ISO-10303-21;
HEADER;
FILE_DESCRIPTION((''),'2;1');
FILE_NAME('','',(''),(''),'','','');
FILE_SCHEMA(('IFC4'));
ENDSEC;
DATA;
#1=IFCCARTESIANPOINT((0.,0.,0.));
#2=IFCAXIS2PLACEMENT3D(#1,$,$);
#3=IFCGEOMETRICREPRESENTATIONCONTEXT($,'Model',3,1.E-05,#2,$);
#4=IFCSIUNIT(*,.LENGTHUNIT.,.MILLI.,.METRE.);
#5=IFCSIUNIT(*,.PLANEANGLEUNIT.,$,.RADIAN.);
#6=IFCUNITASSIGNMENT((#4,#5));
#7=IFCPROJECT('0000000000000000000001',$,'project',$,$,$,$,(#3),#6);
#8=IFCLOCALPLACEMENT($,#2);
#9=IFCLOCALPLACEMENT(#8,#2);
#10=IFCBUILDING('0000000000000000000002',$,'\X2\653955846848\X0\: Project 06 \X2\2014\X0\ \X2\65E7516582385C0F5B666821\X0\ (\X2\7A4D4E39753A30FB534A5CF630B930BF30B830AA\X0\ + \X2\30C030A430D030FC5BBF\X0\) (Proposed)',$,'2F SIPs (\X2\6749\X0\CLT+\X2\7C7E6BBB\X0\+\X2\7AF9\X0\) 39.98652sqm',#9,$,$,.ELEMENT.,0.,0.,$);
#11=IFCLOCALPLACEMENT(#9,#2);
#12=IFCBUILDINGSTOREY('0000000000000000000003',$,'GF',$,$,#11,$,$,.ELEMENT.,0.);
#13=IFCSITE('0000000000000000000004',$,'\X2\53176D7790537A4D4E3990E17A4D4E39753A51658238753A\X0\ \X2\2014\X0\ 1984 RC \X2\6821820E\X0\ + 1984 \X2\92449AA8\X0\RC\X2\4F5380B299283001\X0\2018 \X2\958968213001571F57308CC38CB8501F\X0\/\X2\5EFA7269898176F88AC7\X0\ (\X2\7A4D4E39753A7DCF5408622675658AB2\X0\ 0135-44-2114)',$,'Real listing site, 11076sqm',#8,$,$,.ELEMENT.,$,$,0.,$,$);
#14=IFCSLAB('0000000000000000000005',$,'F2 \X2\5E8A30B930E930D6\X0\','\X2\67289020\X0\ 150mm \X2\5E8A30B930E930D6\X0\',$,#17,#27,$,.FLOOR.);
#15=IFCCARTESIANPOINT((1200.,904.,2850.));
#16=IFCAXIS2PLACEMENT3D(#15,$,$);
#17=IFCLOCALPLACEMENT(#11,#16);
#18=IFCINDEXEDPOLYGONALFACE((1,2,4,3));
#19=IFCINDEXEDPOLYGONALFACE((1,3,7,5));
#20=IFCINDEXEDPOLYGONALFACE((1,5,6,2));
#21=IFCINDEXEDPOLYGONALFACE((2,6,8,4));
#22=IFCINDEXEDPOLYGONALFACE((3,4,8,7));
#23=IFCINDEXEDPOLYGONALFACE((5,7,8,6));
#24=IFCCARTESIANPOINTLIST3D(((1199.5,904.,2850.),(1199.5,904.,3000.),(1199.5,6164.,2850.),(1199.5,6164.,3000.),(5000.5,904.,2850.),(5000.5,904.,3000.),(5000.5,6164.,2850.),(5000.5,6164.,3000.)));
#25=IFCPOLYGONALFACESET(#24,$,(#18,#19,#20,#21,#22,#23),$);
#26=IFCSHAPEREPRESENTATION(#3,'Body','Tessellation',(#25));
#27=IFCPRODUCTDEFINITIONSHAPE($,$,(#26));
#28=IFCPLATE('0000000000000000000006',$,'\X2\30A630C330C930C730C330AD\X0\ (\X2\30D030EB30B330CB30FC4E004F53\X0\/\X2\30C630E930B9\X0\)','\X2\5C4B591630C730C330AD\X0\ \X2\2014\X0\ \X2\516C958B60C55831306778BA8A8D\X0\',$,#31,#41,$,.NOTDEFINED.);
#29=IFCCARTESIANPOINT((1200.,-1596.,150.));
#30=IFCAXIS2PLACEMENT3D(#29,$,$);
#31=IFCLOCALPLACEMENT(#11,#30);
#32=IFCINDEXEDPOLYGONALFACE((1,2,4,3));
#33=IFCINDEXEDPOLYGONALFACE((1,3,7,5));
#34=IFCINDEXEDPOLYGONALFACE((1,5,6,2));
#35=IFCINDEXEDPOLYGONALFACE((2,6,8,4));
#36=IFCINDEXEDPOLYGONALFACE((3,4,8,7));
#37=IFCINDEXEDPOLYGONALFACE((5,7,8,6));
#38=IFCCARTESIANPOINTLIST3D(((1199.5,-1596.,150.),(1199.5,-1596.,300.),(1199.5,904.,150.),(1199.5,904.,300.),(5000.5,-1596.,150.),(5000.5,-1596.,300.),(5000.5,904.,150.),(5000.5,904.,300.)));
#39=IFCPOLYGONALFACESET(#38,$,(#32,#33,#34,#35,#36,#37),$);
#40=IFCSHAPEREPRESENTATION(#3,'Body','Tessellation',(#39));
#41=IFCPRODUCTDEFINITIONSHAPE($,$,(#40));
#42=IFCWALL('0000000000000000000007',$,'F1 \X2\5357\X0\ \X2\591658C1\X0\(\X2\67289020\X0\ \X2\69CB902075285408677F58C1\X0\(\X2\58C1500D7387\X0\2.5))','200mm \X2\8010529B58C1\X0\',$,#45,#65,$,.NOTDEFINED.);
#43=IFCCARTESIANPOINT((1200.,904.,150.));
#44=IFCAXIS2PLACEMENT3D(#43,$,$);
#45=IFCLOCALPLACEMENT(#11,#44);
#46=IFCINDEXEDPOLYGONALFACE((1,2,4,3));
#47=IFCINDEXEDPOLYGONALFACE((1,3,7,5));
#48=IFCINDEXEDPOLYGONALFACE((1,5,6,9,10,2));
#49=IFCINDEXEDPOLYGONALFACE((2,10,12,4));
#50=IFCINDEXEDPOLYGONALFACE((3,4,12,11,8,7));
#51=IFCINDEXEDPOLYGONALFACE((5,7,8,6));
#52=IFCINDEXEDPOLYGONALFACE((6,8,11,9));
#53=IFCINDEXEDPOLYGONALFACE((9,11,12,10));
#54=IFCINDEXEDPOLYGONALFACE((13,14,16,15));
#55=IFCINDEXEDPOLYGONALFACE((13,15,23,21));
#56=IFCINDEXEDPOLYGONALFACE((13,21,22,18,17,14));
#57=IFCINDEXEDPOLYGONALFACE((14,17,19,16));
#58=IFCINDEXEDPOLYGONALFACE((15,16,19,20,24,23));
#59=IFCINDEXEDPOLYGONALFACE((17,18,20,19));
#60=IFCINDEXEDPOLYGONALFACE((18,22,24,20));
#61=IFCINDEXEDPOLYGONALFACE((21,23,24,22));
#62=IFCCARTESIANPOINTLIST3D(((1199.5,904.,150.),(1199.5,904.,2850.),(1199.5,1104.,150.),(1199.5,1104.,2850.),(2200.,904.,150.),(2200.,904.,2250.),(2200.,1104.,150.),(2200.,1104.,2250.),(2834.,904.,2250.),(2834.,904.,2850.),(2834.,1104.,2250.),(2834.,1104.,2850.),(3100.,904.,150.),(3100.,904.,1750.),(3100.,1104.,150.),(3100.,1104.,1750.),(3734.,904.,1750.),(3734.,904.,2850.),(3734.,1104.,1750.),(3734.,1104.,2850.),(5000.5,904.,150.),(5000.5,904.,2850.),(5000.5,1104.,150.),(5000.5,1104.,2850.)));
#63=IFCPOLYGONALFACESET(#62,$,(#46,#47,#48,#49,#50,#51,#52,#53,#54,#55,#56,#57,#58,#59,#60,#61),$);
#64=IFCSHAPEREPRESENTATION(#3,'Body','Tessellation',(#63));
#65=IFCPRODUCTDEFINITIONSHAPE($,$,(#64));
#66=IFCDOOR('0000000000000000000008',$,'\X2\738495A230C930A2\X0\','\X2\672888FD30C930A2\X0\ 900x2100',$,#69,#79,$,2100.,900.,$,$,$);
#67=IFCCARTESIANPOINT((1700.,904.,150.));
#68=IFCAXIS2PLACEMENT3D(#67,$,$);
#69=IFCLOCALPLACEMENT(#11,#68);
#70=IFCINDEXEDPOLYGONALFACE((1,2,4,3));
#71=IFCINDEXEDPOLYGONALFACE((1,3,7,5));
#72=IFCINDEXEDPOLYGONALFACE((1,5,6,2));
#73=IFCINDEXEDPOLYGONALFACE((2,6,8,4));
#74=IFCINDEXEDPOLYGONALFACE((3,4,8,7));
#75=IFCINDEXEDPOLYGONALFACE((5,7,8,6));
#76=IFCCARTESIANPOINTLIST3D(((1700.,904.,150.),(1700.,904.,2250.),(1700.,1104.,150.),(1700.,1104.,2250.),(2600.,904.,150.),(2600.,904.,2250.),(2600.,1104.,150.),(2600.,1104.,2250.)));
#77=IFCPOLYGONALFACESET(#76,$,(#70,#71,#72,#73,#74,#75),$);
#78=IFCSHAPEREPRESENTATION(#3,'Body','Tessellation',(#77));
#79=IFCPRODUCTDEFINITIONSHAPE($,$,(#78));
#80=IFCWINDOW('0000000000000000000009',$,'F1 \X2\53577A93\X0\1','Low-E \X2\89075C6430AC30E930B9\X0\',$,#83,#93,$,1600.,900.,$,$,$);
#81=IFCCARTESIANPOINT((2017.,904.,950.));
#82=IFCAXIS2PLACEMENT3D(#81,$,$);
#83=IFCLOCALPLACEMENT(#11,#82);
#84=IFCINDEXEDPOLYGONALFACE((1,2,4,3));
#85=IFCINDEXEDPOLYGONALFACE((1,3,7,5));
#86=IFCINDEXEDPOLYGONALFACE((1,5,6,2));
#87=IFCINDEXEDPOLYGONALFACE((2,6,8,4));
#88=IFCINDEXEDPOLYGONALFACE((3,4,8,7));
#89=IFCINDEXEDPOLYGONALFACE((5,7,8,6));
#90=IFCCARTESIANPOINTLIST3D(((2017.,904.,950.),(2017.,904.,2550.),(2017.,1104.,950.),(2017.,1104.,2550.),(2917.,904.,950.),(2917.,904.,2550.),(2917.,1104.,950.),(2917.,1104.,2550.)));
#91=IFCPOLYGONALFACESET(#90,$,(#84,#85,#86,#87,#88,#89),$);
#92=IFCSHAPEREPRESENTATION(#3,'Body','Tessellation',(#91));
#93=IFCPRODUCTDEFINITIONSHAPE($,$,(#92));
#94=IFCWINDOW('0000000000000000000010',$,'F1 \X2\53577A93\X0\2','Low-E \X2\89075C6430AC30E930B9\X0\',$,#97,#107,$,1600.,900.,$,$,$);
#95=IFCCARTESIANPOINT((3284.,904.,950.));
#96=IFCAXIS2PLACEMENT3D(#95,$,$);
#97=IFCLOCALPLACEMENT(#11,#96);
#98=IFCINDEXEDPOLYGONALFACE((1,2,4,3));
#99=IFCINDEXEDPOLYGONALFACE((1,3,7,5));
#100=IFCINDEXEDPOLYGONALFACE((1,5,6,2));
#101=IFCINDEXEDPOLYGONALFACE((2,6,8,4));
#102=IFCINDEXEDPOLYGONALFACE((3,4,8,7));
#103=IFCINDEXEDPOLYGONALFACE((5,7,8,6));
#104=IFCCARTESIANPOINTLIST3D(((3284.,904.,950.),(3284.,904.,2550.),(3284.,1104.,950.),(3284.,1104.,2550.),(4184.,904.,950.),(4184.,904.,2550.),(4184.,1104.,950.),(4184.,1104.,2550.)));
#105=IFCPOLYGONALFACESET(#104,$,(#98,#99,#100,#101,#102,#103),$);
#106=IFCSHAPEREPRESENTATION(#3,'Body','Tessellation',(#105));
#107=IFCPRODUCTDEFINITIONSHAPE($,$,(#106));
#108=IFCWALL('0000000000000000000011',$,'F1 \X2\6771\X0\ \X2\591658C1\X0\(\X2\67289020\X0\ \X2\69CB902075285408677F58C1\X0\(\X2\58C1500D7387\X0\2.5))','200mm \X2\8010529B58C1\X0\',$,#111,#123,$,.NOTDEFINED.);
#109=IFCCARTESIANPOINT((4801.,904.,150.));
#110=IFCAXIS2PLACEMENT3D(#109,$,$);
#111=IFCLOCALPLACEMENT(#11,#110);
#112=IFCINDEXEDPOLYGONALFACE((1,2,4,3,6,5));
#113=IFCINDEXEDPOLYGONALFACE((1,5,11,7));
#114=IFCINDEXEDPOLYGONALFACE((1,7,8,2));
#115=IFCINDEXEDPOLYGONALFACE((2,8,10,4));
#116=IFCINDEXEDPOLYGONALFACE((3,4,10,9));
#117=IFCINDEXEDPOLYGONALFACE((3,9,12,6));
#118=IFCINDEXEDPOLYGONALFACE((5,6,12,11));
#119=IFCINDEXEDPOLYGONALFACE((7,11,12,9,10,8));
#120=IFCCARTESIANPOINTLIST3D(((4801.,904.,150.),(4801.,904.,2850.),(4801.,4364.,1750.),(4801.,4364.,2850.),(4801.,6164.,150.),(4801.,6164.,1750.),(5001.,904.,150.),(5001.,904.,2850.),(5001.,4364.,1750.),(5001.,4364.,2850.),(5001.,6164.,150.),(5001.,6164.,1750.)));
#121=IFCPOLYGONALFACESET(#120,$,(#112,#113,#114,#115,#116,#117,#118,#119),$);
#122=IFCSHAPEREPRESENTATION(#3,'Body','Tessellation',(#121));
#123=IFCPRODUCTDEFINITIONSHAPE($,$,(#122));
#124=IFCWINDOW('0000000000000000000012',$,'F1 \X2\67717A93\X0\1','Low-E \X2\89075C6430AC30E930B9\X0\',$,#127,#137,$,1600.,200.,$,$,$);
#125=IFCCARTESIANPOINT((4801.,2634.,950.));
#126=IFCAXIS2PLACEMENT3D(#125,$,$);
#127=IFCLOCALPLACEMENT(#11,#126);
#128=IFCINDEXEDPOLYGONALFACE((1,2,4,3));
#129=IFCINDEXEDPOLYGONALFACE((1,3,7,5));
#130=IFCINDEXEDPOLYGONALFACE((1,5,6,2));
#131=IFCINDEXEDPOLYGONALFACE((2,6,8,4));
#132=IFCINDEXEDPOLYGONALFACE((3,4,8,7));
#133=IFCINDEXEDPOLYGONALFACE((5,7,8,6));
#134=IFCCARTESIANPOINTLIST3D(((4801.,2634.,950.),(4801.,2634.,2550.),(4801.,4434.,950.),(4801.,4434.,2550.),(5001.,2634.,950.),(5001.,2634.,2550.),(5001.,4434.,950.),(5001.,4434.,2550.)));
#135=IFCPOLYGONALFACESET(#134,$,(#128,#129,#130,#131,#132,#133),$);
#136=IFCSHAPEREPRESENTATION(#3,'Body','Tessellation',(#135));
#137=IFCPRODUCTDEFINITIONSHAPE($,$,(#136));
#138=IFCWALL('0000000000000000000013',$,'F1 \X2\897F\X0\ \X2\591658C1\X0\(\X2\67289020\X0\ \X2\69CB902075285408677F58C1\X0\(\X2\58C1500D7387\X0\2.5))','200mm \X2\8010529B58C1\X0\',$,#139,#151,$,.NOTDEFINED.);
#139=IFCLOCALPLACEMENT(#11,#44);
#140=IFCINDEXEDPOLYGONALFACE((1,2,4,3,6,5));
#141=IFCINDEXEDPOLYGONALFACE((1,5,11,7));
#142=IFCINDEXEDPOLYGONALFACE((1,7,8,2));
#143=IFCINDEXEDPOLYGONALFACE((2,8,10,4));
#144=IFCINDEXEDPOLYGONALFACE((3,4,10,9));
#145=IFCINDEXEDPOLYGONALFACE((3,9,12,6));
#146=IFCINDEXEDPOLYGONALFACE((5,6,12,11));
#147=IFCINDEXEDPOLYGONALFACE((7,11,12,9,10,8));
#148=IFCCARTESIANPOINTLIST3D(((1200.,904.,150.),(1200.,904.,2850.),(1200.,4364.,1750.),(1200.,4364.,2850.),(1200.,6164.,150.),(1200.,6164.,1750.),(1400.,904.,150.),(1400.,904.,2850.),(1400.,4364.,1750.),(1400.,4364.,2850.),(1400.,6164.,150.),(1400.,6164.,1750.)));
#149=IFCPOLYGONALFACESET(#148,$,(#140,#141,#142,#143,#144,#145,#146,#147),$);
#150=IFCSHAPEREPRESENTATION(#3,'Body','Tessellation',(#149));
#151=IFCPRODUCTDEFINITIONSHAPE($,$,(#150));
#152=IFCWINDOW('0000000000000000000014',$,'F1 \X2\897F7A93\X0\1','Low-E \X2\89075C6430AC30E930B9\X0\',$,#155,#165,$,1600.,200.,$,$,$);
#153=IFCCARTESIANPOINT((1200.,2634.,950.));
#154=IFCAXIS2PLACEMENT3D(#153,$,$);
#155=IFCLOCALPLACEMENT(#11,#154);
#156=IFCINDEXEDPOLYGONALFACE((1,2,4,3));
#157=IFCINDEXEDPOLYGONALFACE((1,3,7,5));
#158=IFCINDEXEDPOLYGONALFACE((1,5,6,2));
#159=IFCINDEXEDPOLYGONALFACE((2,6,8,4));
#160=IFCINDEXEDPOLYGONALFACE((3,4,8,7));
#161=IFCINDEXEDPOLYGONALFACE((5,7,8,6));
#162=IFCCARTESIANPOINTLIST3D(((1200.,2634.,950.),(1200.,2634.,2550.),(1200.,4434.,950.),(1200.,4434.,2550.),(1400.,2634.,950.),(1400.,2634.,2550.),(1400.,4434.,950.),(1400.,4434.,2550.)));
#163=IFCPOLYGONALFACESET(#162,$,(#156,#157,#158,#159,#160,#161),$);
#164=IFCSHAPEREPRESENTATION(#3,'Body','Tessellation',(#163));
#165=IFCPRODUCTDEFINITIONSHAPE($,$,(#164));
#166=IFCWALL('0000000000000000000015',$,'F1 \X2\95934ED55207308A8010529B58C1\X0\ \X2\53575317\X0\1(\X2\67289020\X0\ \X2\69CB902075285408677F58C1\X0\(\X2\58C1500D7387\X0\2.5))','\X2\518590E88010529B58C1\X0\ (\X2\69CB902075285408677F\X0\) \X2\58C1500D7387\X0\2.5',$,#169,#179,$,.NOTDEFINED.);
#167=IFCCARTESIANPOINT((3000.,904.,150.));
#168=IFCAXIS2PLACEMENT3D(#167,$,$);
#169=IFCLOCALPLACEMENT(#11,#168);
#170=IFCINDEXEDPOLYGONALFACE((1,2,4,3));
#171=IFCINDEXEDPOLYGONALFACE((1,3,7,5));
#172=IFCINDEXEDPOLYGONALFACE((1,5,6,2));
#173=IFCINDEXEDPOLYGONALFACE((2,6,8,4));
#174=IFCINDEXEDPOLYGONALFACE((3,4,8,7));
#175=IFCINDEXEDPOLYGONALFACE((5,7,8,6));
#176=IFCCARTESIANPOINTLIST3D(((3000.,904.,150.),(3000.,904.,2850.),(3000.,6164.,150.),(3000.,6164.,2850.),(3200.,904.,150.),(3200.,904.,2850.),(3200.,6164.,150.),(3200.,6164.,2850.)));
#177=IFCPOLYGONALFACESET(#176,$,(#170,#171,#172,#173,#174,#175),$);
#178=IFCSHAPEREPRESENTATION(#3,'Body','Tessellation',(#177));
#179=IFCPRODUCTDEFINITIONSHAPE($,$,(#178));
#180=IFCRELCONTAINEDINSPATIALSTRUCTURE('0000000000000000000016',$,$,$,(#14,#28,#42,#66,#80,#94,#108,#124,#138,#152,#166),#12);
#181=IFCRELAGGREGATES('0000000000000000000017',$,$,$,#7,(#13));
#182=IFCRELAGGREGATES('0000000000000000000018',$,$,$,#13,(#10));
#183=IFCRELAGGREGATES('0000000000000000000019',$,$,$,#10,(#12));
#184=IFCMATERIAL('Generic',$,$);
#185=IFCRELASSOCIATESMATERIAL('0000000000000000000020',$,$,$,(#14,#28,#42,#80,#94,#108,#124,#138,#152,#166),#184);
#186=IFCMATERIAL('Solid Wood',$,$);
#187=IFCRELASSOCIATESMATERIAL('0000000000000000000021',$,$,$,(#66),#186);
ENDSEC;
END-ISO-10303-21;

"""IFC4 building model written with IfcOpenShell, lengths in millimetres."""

from ifc_helpers import new_model, si_unit, frame, frame_2d, origin, place, context, project, spatial, rectangle, extrude, material, element, fill, save


model = new_model("IFC4")

# Units and contexts
model_context = context("Model", 3, precision=1e-05, world=origin())
ifc_project = project(units=[si_unit("LENGTHUNIT", "METRE", prefix="MILLI"), si_unit("PLANEANGLEUNIT", "RADIAN")], contexts=[model_context])

# Site, building, storey
site_placement = place(None, origin())
site = spatial("IfcSite", under=ifc_project, at=site_placement, Name="北海道積丹郡積丹町入舸町 — 1984 RC 校舎 + 1984 鉄骨RC体育館、2018 閉校、土地賃貸借/建物要相談 (積丹町総合戦略課 0135-44-2114)", ObjectType="Real listing site, 11076sqm", CompositionType="ELEMENT", RefElevation=0.0)
building_placement = place(site_placement, origin())
building = spatial("IfcBuilding", under=site, at=building_placement, Name="改善案: Project 06 — 旧入舸小学校 (積丹町・半島スタジオ + ダイバー宿) (Proposed)", ObjectType="2F SIPs (杉CLT+籾殻+竹) 39.98652sqm", CompositionType="ELEMENT", ElevationOfRefHeight=0.0, ElevationOfTerrain=0.0)
storey_placement = place(building_placement, origin())
storey = spatial("IfcBuildingStorey", under=building, at=storey_placement, Name="GF", CompositionType="ELEMENT", Elevation=0.0)

# Slab
ifc_material_1 = material(Name="Generic")
slab_1_placement = place(storey_placement, frame((1200.0, 904.0, 2850.0)))
element("IfcSlab", 1, at=slab_1_placement, inside=storey, material=ifc_material_1, Name="F2 床スラブ", Description="木造 150mm 床スラブ", PredefinedType="FLOOR", context=model_context, shape_type="SweptSolid", body=[
    extrude(rectangle(XDim=3801.0, YDim=5260.0, at=frame_2d((1900.0, 2630.0))), frame((1200.0, 904.0, 2850.0)), (0.0, 0.0, 1.0), 150.0),
])

# Plate
plate_placement = place(storey_placement, frame((1200.0, -1596.0, 150.0)))
element("IfcPlate", 2, at=plate_placement, inside=storey, material=ifc_material_1, Name="ウッドデッキ (バルコニー一体/テラス)", Description="屋外デッキ — 公開情報で確認", PredefinedType="NOTDEFINED", context=model_context, shape_type="SweptSolid", body=[
    extrude(rectangle(XDim=3801.0, YDim=2500.0, at=frame_2d((1900.0, 1250.0))), frame((1200.0, -1596.0, 150.0)), (0.0, 0.0, 1.0), 150.0),
])

# Wall, openings, door, windows
wall_1_placement = place(storey_placement, frame((1200.0, 904.0, 150.0)))
wall_1 = element("IfcWall", 3, at=wall_1_placement, inside=storey, material=ifc_material_1, Name="F1 南 外壁(木造 構造用合板壁(壁倍率2.5))", Description="200mm 耐力壁", PredefinedType="NOTDEFINED", context=model_context, shape_type="SweptSolid", body=[
    extrude(rectangle(XDim=3801.0, YDim=200.0, at=frame_2d((1900.0, 100.0))), frame((1200.0, 904.0, 150.0)), (0.0, 0.0, 1.0), 2700.0),
])
opening_1_placement = place(storey_placement, frame((1700.0, 904.0, 150.0)))
opening_1 = element("IfcOpeningElement", 4, at=opening_1_placement, cuts=wall_1, PredefinedType="NOTDEFINED", context=model_context, shape_type="SweptSolid", body=[
    extrude(rectangle(XDim=900.0, YDim=200.0, at=frame_2d((450.0, 100.0))), frame((1700.0, 904.0, 150.0)), (0.0, 0.0, 1.0), 2100.0),
])
opening_2_placement = place(storey_placement, frame((2017.0, 904.0, 950.0)))
opening_2 = element("IfcOpeningElement", 5, at=opening_2_placement, cuts=wall_1, PredefinedType="NOTDEFINED", context=model_context, shape_type="SweptSolid", body=[
    extrude(rectangle(XDim=900.0, YDim=200.0, at=frame_2d((450.0, 100.0))), frame((2017.0, 904.0, 950.0)), (0.0, 0.0, 1.0), 1600.0),
])
opening_3_placement = place(storey_placement, frame((3284.0, 904.0, 950.0)))
opening_3 = element("IfcOpeningElement", 6, at=opening_3_placement, cuts=wall_1, PredefinedType="NOTDEFINED", context=model_context, shape_type="SweptSolid", body=[
    extrude(rectangle(XDim=900.0, YDim=200.0, at=frame_2d((450.0, 100.0))), frame((3284.0, 904.0, 950.0)), (0.0, 0.0, 1.0), 1600.0),
])
ifc_material_2 = material(Name="Solid Wood")
door_placement = place(storey_placement, frame((1700.0, 904.0, 150.0)))
door = element("IfcDoor", 7, at=door_placement, inside=storey, material=ifc_material_2, Name="玄関ドア", Description="木製ドア 900x2100", OverallHeight=2100.0, OverallWidth=900.0, context=model_context, shape_type="SweptSolid", body=[
    extrude(rectangle(XDim=900.0, YDim=200.0, at=frame_2d((450.0, 100.0))), frame((1700.0, 904.0, 150.0)), (0.0, 0.0, 1.0), 2100.0),
])
fill(opening_1, door)
window_1_placement = place(storey_placement, frame((2017.0, 904.0, 950.0)))
window_1 = element("IfcWindow", 8, at=window_1_placement, inside=storey, material=ifc_material_1, Name="F1 南窓1", Description="Low-E 複層ガラス", OverallHeight=1600.0, OverallWidth=900.0, context=model_context, shape_type="SweptSolid", body=[
    extrude(rectangle(XDim=900.0, YDim=200.0, at=frame_2d((450.0, 100.0))), frame((2017.0, 904.0, 950.0)), (0.0, 0.0, 1.0), 1600.0),
])
fill(opening_2, window_1)
window_2_placement = place(storey_placement, frame((3284.0, 904.0, 950.0)))
window_2 = element("IfcWindow", 9, at=window_2_placement, inside=storey, material=ifc_material_1, Name="F1 南窓2", Description="Low-E 複層ガラス", OverallHeight=1600.0, OverallWidth=900.0, context=model_context, shape_type="SweptSolid", body=[
    extrude(rectangle(XDim=900.0, YDim=200.0, at=frame_2d((450.0, 100.0))), frame((3284.0, 904.0, 950.0)), (0.0, 0.0, 1.0), 1600.0),
])
fill(opening_3, window_2)

# Walls, openings, windows
wall_2_placement = place(storey_placement, frame((4801.0, 904.0, 150.0)))
wall_2 = element("IfcWall", 10, at=wall_2_placement, inside=storey, material=ifc_material_1, Name="F1 東 外壁(木造 構造用合板壁(壁倍率2.5))", Description="200mm 耐力壁", PredefinedType="NOTDEFINED", context=model_context, shape_type="SweptSolid", body=[
    extrude(rectangle(XDim=200.0, YDim=5260.0, at=frame_2d((100.0, 2630.0))), frame((4801.0, 904.0, 150.0)), (0.0, 0.0, 1.0), 2700.0),
])
opening_4_placement = place(storey_placement, frame((4801.0, 2634.0, 950.0)))
opening_4 = element("IfcOpeningElement", 11, at=opening_4_placement, cuts=wall_2, PredefinedType="NOTDEFINED", context=model_context, shape_type="SweptSolid", body=[
    extrude(rectangle(XDim=200.0, YDim=1800.0, at=frame_2d((100.0, 900.0))), frame((4801.0, 2634.0, 950.0)), (0.0, 0.0, 1.0), 1600.0),
])
window_3_placement = place(storey_placement, frame((4801.0, 2634.0, 950.0)))
window_3 = element("IfcWindow", 12, at=window_3_placement, inside=storey, material=ifc_material_1, Name="F1 東窓1", Description="Low-E 複層ガラス", OverallHeight=1600.0, OverallWidth=200.0, context=model_context, shape_type="SweptSolid", body=[
    extrude(rectangle(XDim=200.0, YDim=1800.0, at=frame_2d((100.0, 900.0))), frame((4801.0, 2634.0, 950.0)), (0.0, 0.0, 1.0), 1600.0),
])
fill(opening_4, window_3)
wall_3_placement = place(storey_placement, frame((1200.0, 904.0, 150.0)))
wall_3 = element("IfcWall", 13, at=wall_3_placement, inside=storey, material=ifc_material_1, Name="F1 西 外壁(木造 構造用合板壁(壁倍率2.5))", Description="200mm 耐力壁", PredefinedType="NOTDEFINED", context=model_context, shape_type="SweptSolid", body=[
    extrude(rectangle(XDim=200.0, YDim=5260.0, at=frame_2d((100.0, 2630.0))), frame((1200.0, 904.0, 150.0)), (0.0, 0.0, 1.0), 2700.0),
])
opening_5_placement = place(storey_placement, frame((1200.0, 2634.0, 950.0)))
opening_5 = element("IfcOpeningElement", 14, at=opening_5_placement, cuts=wall_3, PredefinedType="NOTDEFINED", context=model_context, shape_type="SweptSolid", body=[
    extrude(rectangle(XDim=200.0, YDim=1800.0, at=frame_2d((100.0, 900.0))), frame((1200.0, 2634.0, 950.0)), (0.0, 0.0, 1.0), 1600.0),
])
window_4_placement = place(storey_placement, frame((1200.0, 2634.0, 950.0)))
window_4 = element("IfcWindow", 15, at=window_4_placement, inside=storey, material=ifc_material_1, Name="F1 西窓1", Description="Low-E 複層ガラス", OverallHeight=1600.0, OverallWidth=200.0, context=model_context, shape_type="SweptSolid", body=[
    extrude(rectangle(XDim=200.0, YDim=1800.0, at=frame_2d((100.0, 900.0))), frame((1200.0, 2634.0, 950.0)), (0.0, 0.0, 1.0), 1600.0),
])
fill(opening_5, window_4)

# Wall
wall_4_placement = place(storey_placement, frame((3000.0, 904.0, 150.0)))
element("IfcWall", 16, at=wall_4_placement, inside=storey, material=ifc_material_1, Name="F1 間仕切り耐力壁 南北1(木造 構造用合板壁(壁倍率2.5))", Description="内部耐力壁 (構造用合板) 壁倍率2.5", PredefinedType="NOTDEFINED", context=model_context, shape_type="SweptSolid", body=[
    extrude(rectangle(XDim=200.0, YDim=5260.0, at=frame_2d((100.0, 2630.0))), frame((3000.0, 904.0, 150.0)), (0.0, 0.0, 1.0), 2700.0),
])

save(model, "model.ifc")
